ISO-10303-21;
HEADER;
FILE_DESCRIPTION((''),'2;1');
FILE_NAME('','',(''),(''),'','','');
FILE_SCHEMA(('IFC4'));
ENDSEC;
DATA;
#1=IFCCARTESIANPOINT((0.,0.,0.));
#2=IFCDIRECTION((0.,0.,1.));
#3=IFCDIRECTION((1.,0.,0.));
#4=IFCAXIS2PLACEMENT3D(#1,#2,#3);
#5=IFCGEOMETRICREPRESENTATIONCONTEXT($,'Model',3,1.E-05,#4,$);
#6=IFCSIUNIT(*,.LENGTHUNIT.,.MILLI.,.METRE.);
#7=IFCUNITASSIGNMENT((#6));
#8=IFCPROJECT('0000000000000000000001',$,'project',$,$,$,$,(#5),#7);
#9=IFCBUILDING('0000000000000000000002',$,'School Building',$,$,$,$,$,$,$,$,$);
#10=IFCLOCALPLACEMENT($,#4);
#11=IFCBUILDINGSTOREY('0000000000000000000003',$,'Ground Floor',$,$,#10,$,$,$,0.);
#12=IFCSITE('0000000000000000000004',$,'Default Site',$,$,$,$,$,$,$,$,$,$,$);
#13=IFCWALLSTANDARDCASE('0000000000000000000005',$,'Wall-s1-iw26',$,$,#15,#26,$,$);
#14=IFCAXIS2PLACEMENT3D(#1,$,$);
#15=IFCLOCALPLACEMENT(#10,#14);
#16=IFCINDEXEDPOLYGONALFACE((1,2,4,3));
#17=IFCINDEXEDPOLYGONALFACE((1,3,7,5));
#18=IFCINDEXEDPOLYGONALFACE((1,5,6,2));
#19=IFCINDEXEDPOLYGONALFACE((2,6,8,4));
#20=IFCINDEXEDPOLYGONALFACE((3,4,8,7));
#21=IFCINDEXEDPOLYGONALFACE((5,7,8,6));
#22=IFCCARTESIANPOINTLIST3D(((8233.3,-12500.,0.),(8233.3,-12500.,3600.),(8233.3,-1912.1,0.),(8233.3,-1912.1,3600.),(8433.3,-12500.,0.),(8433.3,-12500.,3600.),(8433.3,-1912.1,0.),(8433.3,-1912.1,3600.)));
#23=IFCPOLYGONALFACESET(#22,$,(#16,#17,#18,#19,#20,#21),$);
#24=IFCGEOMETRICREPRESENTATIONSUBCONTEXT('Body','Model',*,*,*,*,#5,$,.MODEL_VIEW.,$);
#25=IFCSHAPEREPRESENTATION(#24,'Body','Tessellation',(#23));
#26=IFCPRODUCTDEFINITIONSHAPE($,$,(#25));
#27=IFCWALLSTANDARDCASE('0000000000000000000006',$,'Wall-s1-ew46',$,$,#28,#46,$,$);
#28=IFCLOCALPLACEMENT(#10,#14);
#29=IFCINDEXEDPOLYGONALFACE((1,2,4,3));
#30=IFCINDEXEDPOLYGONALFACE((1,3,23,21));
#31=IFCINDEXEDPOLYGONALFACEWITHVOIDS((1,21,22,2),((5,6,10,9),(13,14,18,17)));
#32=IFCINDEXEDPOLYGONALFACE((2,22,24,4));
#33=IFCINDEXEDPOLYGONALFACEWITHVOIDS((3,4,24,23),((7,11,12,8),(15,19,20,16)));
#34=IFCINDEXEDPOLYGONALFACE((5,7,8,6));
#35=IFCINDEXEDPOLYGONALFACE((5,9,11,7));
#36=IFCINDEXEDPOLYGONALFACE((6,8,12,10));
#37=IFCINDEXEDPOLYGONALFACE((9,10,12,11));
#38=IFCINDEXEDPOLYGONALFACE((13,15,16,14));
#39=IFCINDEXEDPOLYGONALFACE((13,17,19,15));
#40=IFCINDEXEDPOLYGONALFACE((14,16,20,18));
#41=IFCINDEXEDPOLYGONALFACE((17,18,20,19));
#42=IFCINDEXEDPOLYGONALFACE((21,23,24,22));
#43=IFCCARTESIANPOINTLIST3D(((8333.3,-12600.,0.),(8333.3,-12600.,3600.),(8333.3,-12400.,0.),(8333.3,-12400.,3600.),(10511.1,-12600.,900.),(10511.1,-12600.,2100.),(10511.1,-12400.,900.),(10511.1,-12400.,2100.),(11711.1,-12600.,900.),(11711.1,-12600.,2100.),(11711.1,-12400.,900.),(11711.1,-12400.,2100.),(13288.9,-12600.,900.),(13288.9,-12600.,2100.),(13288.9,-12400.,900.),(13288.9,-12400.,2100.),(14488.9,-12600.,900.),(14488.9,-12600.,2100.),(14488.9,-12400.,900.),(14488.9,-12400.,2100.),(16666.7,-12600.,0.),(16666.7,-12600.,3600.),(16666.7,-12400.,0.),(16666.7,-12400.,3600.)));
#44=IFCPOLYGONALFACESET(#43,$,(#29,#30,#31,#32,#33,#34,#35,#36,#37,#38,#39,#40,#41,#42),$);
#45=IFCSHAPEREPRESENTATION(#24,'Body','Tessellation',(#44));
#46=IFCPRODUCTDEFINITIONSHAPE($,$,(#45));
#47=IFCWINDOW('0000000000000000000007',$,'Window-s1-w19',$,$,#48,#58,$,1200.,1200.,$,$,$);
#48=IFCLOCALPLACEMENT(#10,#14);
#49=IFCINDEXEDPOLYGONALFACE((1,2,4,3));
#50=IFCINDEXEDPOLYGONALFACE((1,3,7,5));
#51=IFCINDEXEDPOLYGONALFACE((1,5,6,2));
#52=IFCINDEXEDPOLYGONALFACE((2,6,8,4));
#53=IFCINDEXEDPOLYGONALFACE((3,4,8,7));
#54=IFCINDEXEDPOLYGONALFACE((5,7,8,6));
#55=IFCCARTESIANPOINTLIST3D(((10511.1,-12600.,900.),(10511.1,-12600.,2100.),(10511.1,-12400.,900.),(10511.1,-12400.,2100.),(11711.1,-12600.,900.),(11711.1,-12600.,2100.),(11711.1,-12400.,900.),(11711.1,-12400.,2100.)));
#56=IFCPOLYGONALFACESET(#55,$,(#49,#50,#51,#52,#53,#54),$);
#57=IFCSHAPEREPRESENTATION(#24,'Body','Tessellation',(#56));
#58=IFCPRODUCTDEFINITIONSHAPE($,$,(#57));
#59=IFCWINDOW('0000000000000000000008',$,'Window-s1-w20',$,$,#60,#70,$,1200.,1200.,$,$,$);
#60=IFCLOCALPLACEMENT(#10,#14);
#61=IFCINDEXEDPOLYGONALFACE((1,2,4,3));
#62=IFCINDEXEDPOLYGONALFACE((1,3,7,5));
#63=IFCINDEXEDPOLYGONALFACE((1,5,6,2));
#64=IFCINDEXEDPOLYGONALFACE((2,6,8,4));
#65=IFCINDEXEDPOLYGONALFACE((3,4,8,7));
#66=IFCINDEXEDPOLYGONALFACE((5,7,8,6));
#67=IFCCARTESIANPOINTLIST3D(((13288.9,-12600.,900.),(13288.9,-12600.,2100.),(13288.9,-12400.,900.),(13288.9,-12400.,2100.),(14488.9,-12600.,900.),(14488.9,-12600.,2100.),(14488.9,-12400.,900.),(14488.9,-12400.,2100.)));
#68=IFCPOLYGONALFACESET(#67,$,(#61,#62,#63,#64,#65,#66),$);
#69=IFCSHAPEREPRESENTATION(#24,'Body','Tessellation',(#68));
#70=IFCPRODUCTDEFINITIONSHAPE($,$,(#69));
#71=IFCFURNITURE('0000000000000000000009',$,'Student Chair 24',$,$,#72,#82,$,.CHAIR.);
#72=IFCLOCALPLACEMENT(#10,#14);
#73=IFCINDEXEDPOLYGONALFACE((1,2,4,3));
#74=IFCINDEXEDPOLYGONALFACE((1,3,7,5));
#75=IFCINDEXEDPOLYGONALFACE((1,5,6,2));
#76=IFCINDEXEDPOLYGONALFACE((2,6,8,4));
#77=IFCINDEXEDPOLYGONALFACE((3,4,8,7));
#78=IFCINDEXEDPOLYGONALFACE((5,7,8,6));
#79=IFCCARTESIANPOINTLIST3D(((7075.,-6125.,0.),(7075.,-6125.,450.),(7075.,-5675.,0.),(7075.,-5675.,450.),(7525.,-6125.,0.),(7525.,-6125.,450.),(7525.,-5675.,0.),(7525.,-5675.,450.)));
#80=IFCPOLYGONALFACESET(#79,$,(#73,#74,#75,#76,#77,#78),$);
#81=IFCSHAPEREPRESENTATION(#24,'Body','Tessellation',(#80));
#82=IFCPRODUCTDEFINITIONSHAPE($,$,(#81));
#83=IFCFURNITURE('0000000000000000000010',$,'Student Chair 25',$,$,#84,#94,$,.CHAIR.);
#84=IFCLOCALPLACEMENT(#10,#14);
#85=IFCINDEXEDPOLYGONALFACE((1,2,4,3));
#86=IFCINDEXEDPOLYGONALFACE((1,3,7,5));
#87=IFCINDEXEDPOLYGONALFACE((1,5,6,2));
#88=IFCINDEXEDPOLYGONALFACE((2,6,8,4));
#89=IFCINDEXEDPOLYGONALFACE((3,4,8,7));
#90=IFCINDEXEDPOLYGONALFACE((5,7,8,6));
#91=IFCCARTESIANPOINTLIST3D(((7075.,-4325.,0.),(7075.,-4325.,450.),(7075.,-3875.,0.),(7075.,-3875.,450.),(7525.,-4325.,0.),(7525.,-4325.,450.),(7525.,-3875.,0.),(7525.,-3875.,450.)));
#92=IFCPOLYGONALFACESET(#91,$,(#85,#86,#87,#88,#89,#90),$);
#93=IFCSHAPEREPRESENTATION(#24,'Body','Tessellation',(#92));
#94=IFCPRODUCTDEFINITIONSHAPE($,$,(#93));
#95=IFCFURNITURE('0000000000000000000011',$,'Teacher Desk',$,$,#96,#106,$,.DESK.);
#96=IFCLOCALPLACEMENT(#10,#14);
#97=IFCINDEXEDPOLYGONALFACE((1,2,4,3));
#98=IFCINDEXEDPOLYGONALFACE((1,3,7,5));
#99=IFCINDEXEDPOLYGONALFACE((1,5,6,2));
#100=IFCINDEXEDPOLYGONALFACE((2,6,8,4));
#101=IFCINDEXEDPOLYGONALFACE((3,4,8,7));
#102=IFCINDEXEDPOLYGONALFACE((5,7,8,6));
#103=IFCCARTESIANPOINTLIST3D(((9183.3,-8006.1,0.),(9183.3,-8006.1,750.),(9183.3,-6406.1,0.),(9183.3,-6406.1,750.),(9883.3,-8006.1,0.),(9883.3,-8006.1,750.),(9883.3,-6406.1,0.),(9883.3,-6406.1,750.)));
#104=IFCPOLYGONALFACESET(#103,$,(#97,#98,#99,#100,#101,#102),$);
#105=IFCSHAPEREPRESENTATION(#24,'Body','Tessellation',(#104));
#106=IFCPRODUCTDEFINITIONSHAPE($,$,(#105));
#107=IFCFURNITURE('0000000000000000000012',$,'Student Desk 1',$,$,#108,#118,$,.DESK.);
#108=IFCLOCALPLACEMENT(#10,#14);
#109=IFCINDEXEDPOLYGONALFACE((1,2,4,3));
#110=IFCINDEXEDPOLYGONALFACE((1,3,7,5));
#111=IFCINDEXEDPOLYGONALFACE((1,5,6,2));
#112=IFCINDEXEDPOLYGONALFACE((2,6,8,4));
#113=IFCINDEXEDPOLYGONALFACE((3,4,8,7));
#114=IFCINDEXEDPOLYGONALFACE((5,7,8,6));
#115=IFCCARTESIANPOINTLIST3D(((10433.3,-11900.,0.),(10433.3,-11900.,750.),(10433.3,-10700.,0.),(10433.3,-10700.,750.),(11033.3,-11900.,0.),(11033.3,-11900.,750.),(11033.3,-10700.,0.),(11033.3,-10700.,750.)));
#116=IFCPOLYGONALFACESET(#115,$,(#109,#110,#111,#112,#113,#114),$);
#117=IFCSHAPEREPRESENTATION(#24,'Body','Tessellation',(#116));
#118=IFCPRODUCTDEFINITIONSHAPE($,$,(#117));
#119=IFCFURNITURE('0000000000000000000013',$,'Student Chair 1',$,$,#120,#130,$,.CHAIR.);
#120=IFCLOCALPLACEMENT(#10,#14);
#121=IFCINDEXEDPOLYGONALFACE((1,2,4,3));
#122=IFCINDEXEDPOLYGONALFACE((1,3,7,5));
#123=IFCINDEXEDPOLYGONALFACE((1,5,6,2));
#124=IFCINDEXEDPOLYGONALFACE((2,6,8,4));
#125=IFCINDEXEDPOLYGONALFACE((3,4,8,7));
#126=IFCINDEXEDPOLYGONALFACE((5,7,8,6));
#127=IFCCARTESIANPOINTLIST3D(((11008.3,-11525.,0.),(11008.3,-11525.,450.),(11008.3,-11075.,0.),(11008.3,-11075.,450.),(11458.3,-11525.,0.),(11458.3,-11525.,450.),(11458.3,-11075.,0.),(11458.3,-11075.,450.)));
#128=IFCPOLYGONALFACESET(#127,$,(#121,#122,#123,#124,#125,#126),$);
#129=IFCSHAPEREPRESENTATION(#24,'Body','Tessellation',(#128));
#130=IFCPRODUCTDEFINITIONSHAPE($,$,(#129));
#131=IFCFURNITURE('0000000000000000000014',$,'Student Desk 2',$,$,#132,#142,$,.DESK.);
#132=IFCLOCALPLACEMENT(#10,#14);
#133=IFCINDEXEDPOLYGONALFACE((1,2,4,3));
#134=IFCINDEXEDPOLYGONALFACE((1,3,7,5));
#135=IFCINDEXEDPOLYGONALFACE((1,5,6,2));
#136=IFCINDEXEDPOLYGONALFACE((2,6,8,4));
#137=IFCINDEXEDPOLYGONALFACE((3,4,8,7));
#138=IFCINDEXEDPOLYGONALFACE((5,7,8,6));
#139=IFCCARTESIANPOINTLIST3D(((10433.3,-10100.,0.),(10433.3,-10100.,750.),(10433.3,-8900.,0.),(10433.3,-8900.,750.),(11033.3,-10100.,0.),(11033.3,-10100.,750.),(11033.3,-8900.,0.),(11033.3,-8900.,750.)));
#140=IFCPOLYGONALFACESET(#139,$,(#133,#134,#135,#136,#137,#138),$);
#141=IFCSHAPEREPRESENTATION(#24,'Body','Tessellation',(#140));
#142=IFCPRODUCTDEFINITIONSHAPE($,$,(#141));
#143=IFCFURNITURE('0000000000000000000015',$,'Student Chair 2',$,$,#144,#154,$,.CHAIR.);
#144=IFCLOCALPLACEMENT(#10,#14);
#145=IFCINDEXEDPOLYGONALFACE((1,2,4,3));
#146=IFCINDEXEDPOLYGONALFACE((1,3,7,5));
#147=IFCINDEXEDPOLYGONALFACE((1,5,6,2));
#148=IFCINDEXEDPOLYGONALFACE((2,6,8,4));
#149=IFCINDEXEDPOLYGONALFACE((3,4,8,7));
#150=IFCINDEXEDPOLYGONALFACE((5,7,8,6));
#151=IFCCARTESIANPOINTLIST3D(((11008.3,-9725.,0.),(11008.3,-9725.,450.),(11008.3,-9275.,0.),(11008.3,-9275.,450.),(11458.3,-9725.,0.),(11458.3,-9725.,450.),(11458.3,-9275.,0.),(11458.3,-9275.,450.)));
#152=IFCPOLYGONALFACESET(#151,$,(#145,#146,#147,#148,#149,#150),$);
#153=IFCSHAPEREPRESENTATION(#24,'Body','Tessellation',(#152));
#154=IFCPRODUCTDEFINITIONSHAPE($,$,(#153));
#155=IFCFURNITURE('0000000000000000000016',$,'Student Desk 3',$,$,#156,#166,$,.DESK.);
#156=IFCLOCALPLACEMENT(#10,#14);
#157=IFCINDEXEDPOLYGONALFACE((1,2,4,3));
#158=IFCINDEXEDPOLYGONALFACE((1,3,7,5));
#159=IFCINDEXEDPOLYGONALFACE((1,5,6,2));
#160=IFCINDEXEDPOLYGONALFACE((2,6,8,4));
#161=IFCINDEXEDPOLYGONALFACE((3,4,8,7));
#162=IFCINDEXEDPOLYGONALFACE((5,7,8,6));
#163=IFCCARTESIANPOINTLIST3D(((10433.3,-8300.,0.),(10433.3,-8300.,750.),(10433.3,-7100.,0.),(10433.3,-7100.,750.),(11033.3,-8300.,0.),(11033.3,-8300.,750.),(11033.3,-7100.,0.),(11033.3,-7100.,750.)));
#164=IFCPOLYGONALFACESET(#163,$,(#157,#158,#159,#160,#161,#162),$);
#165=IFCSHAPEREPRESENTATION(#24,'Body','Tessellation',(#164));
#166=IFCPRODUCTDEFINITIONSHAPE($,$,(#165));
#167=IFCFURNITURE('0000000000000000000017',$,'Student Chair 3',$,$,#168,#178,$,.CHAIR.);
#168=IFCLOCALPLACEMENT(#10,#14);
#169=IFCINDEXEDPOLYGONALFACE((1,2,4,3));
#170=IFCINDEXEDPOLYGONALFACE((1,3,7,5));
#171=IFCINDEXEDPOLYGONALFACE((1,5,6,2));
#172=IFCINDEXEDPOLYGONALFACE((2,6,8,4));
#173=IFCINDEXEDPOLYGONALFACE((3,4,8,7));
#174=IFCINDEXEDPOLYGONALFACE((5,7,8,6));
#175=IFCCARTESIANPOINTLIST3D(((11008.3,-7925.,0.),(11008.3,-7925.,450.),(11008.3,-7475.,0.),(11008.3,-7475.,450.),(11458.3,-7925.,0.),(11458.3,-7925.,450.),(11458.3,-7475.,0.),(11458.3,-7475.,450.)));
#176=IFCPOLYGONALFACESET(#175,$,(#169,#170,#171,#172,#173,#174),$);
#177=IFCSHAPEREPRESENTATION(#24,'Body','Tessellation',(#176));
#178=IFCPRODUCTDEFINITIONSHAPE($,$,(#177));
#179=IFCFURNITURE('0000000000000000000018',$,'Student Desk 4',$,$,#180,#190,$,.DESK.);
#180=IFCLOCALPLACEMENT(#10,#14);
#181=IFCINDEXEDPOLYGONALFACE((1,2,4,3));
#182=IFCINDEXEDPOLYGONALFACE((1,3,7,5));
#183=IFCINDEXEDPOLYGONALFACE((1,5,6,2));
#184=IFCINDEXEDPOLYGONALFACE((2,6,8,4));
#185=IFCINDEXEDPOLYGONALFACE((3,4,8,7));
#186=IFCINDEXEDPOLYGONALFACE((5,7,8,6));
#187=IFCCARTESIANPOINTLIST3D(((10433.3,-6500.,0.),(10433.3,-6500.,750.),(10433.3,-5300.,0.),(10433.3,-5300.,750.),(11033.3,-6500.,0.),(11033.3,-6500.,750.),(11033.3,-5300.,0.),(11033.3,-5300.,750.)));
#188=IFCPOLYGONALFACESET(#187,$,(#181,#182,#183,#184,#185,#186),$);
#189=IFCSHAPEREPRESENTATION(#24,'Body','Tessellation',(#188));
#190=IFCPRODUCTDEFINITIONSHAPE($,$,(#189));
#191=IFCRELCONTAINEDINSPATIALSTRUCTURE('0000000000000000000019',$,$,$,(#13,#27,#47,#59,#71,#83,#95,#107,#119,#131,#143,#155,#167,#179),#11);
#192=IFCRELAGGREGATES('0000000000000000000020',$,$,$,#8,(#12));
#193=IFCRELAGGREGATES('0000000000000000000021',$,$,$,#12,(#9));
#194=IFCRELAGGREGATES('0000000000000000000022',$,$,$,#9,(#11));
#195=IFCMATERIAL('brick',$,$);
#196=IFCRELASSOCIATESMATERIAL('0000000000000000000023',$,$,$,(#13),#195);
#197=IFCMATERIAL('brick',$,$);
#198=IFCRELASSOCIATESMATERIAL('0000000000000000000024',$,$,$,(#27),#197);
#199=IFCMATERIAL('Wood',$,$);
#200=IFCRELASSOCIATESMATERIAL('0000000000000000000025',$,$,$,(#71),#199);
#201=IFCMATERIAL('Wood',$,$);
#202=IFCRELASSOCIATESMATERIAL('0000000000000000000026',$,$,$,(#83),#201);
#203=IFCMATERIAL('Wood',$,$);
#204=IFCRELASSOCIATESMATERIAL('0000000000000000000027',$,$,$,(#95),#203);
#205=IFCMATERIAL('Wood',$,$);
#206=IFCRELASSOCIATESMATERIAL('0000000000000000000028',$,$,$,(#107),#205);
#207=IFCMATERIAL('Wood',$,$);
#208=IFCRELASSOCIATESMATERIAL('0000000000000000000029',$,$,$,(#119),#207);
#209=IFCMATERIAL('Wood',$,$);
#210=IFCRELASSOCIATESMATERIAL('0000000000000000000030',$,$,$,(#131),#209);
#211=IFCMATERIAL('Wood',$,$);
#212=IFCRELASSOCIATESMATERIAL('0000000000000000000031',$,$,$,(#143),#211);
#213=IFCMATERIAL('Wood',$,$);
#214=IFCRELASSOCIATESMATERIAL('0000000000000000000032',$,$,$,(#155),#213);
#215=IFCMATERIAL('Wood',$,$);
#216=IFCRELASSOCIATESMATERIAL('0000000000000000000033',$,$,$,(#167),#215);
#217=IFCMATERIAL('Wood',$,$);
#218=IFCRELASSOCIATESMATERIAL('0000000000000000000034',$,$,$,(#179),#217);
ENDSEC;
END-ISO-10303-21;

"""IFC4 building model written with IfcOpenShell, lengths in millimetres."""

from ifc_helpers import new_model, si_unit, frame, frame_2d, origin_with_axes, origin_2d, place, context, subcontext, project, spatial, rectangle, extrude, material, element, fill, save


model = new_model("IFC4")

# Units and contexts
model_context = context("Model", 3, precision=1e-05, world=origin_with_axes())
body_context = subcontext(model_context, "Body", "Model", "MODEL_VIEW")
ifc_project = project(units=[si_unit("LENGTHUNIT", "METRE", prefix="MILLI")], contexts=[model_context])

# Site, building, storey
site = spatial("IfcSite", under=ifc_project, Name="Default Site")
building = spatial("IfcBuilding", under=site, Name="School Building")
storey_placement = place(None, origin_with_axes())
storey = spatial("IfcBuildingStorey", under=building, at=storey_placement, Name="Ground Floor", Elevation=0.0)

# Wall
ifc_material_1 = material(Name="brick")
wall_1_placement = place(storey_placement, frame((8333.3, -12500.0, 0.0), z_axis=(0.0, 0.0, 1.0), x_axis=(0.0, 1.0, 0.0)))
element("IfcWallStandardCase", 1, at=wall_1_placement, inside=storey, material=ifc_material_1, Name="Wall-s1-iw26", context=body_context, shape_type="SweptSolid", body=[
    extrude(rectangle(XDim=10587.9, YDim=200.0, at=frame_2d((5293.9, 0.0))), origin_with_axes(), (0.0, 0.0, 1.0), 3600.0),
])

# Wall, openings, windows
ifc_material_2 = material(Name="brick")
wall_2_placement = place(storey_placement, frame((8333.3, -12500.0, 0.0), z_axis=(0.0, 0.0, 1.0), x_axis=(1.0, 0.0, 0.0)))
wall_2 = element("IfcWallStandardCase", 2, at=wall_2_placement, inside=storey, material=ifc_material_2, Name="Wall-s1-ew46", context=body_context, shape_type="SweptSolid", body=[
    extrude(rectangle(XDim=8333.3, YDim=200.0, at=frame_2d((4166.7, 0.0))), origin_with_axes(), (0.0, 0.0, 1.0), 3600.0),
])
opening_1_placement = place(wall_2_placement, frame((2177.8, 0.0, 900.0), z_axis=(0.0, 0.0, 1.0), x_axis=(1.0, 0.0, 0.0)))
opening_1 = element("IfcOpeningElement", 3, at=opening_1_placement, cuts=wall_2, context=body_context, shape_type="SweptSolid", body=[
    extrude(rectangle(XDim=1200.0, YDim=400.0, at=frame_2d((600.0, 0.0))), origin_with_axes(), (0.0, 0.0, 1.0), 1200.0),
])
opening_2_placement = place(wall_2_placement, frame((4955.6, 0.0, 900.0), z_axis=(0.0, 0.0, 1.0), x_axis=(1.0, 0.0, 0.0)))
opening_2 = element("IfcOpeningElement", 4, at=opening_2_placement, cuts=wall_2, context=body_context, shape_type="SweptSolid", body=[
    extrude(rectangle(XDim=1200.0, YDim=400.0, at=frame_2d((600.0, 0.0))), origin_with_axes(), (0.0, 0.0, 1.0), 1200.0),
])
window_1_placement = place(storey_placement, frame((10511.1, -12500.0, 900.0), z_axis=(0.0, 0.0, 1.0), x_axis=(1.0, 0.0, 0.0)))
window_1 = element("IfcWindow", 5, at=window_1_placement, inside=storey, Name="Window-s1-w19", OverallHeight=1200.0, OverallWidth=1200.0, context=body_context, shape_type="SweptSolid", body=[
    extrude(rectangle(XDim=1200.0, YDim=200.0, at=frame_2d((600.0, 0.0))), origin_with_axes(), (0.0, 0.0, 1.0), 1200.0),
])
fill(opening_1, window_1)
window_2_placement = place(storey_placement, frame((13288.9, -12500.0, 900.0), z_axis=(0.0, 0.0, 1.0), x_axis=(1.0, 0.0, 0.0)))
window_2 = element("IfcWindow", 6, at=window_2_placement, inside=storey, Name="Window-s1-w20", OverallHeight=1200.0, OverallWidth=1200.0, context=body_context, shape_type="SweptSolid", body=[
    extrude(rectangle(XDim=1200.0, YDim=200.0, at=frame_2d((600.0, 0.0))), origin_with_axes(), (0.0, 0.0, 1.0), 1200.0),
])
fill(opening_2, window_2)

# Furniture
ifc_material_3 = material(Name="Wood")
furniture_1_placement = place(storey_placement, frame((7300.0, -5900.0, 0.0), z_axis=(0.0, 0.0, 1.0), x_axis=(1.0, 0.0, 0.0)))
element("IfcFurniture", 7, at=furniture_1_placement, inside=storey, material=ifc_material_3, Name="Student Chair 24", PredefinedType="CHAIR", context=body_context, shape_type="SweptSolid", body=[
    extrude(rectangle(XDim=450.0, YDim=450.0, at=origin_2d()), origin_with_axes(), (0.0, 0.0, 1.0), 450.0),
])
ifc_material_4 = material(Name="Wood")
furniture_2_placement = place(storey_placement, frame((7300.0, -4100.0, 0.0), z_axis=(0.0, 0.0, 1.0), x_axis=(1.0, 0.0, 0.0)))
element("IfcFurniture", 8, at=furniture_2_placement, inside=storey, material=ifc_material_4, Name="Student Chair 25", PredefinedType="CHAIR", context=body_context, shape_type="SweptSolid", body=[
    extrude(rectangle(XDim=450.0, YDim=450.0, at=origin_2d()), origin_with_axes(), (0.0, 0.0, 1.0), 450.0),
])
ifc_material_5 = material(Name="Wood")
furniture_3_placement = place(storey_placement, frame((9533.3, -7206.1, 0.0), z_axis=(0.0, 0.0, 1.0), x_axis=(0.0, 1.0, 0.0)))
element("IfcFurniture", 9, at=furniture_3_placement, inside=storey, material=ifc_material_5, Name="Teacher Desk", PredefinedType="DESK", context=body_context, shape_type="SweptSolid", body=[
    extrude(rectangle(XDim=1600.0, YDim=700.0, at=origin_2d()), origin_with_axes(), (0.0, 0.0, 1.0), 750.0),
])
ifc_material_6 = material(Name="Wood")
furniture_4_placement = place(storey_placement, frame((10733.3, -11300.0, 0.0), z_axis=(0.0, 0.0, 1.0), x_axis=(0.0, 1.0, 0.0)))
element("IfcFurniture", 10, at=furniture_4_placement, inside=storey, material=ifc_material_6, Name="Student Desk 1", PredefinedType="DESK", context=body_context, shape_type="SweptSolid", body=[
    extrude(rectangle(XDim=1200.0, YDim=600.0, at=origin_2d()), origin_with_axes(), (0.0, 0.0, 1.0), 750.0),
])
ifc_material_7 = material(Name="Wood")
furniture_5_placement = place(storey_placement, frame((11233.3, -11300.0, 0.0), z_axis=(0.0, 0.0, 1.0), x_axis=(1.0, 0.0, 0.0)))
element("IfcFurniture", 11, at=furniture_5_placement, inside=storey, material=ifc_material_7, Name="Student Chair 1", PredefinedType="CHAIR", context=body_context, shape_type="SweptSolid", body=[
    extrude(rectangle(XDim=450.0, YDim=450.0, at=origin_2d()), origin_with_axes(), (0.0, 0.0, 1.0), 450.0),
])
ifc_material_8 = material(Name="Wood")
furniture_6_placement = place(storey_placement, frame((10733.3, -9500.0, 0.0), z_axis=(0.0, 0.0, 1.0), x_axis=(0.0, 1.0, 0.0)))
element("IfcFurniture", 12, at=furniture_6_placement, inside=storey, material=ifc_material_8, Name="Student Desk 2", PredefinedType="DESK", context=body_context, shape_type="SweptSolid", body=[
    extrude(rectangle(XDim=1200.0, YDim=600.0, at=origin_2d()), origin_with_axes(), (0.0, 0.0, 1.0), 750.0),
])
ifc_material_9 = material(Name="Wood")
furniture_7_placement = place(storey_placement, frame((11233.3, -9500.0, 0.0), z_axis=(0.0, 0.0, 1.0), x_axis=(1.0, 0.0, 0.0)))
element("IfcFurniture", 13, at=furniture_7_placement, inside=storey, material=ifc_material_9, Name="Student Chair 2", PredefinedType="CHAIR", context=body_context, shape_type="SweptSolid", body=[
    extrude(rectangle(XDim=450.0, YDim=450.0, at=origin_2d()), origin_with_axes(), (0.0, 0.0, 1.0), 450.0),
])
ifc_material_10 = material(Name="Wood")
furniture_8_placement = place(storey_placement, frame((10733.3, -7700.0, 0.0), z_axis=(0.0, 0.0, 1.0), x_axis=(0.0, 1.0, 0.0)))
element("IfcFurniture", 14, at=furniture_8_placement, inside=storey, material=ifc_material_10, Name="Student Desk 3", PredefinedType="DESK", context=body_context, shape_type="SweptSolid", body=[
    extrude(rectangle(XDim=1200.0, YDim=600.0, at=origin_2d()), origin_with_axes(), (0.0, 0.0, 1.0), 750.0),
])
ifc_material_11 = material(Name="Wood")
furniture_9_placement = place(storey_placement, frame((11233.3, -7700.0, 0.0), z_axis=(0.0, 0.0, 1.0), x_axis=(1.0, 0.0, 0.0)))
element("IfcFurniture", 15, at=furniture_9_placement, inside=storey, material=ifc_material_11, Name="Student Chair 3", PredefinedType="CHAIR", context=body_context, shape_type="SweptSolid", body=[
    extrude(rectangle(XDim=450.0, YDim=450.0, at=origin_2d()), origin_with_axes(), (0.0, 0.0, 1.0), 450.0),
])
ifc_material_12 = material(Name="Wood")
furniture_10_placement = place(storey_placement, frame((10733.3, -5900.0, 0.0), z_axis=(0.0, 0.0, 1.0), x_axis=(0.0, 1.0, 0.0)))
element("IfcFurniture", 16, at=furniture_10_placement, inside=storey, material=ifc_material_12, Name="Student Desk 4", PredefinedType="DESK", context=body_context, shape_type="SweptSolid", body=[
    extrude(rectangle(XDim=1200.0, YDim=600.0, at=origin_2d()), origin_with_axes(), (0.0, 0.0, 1.0), 750.0),
])

save(model, "model.ifc")
